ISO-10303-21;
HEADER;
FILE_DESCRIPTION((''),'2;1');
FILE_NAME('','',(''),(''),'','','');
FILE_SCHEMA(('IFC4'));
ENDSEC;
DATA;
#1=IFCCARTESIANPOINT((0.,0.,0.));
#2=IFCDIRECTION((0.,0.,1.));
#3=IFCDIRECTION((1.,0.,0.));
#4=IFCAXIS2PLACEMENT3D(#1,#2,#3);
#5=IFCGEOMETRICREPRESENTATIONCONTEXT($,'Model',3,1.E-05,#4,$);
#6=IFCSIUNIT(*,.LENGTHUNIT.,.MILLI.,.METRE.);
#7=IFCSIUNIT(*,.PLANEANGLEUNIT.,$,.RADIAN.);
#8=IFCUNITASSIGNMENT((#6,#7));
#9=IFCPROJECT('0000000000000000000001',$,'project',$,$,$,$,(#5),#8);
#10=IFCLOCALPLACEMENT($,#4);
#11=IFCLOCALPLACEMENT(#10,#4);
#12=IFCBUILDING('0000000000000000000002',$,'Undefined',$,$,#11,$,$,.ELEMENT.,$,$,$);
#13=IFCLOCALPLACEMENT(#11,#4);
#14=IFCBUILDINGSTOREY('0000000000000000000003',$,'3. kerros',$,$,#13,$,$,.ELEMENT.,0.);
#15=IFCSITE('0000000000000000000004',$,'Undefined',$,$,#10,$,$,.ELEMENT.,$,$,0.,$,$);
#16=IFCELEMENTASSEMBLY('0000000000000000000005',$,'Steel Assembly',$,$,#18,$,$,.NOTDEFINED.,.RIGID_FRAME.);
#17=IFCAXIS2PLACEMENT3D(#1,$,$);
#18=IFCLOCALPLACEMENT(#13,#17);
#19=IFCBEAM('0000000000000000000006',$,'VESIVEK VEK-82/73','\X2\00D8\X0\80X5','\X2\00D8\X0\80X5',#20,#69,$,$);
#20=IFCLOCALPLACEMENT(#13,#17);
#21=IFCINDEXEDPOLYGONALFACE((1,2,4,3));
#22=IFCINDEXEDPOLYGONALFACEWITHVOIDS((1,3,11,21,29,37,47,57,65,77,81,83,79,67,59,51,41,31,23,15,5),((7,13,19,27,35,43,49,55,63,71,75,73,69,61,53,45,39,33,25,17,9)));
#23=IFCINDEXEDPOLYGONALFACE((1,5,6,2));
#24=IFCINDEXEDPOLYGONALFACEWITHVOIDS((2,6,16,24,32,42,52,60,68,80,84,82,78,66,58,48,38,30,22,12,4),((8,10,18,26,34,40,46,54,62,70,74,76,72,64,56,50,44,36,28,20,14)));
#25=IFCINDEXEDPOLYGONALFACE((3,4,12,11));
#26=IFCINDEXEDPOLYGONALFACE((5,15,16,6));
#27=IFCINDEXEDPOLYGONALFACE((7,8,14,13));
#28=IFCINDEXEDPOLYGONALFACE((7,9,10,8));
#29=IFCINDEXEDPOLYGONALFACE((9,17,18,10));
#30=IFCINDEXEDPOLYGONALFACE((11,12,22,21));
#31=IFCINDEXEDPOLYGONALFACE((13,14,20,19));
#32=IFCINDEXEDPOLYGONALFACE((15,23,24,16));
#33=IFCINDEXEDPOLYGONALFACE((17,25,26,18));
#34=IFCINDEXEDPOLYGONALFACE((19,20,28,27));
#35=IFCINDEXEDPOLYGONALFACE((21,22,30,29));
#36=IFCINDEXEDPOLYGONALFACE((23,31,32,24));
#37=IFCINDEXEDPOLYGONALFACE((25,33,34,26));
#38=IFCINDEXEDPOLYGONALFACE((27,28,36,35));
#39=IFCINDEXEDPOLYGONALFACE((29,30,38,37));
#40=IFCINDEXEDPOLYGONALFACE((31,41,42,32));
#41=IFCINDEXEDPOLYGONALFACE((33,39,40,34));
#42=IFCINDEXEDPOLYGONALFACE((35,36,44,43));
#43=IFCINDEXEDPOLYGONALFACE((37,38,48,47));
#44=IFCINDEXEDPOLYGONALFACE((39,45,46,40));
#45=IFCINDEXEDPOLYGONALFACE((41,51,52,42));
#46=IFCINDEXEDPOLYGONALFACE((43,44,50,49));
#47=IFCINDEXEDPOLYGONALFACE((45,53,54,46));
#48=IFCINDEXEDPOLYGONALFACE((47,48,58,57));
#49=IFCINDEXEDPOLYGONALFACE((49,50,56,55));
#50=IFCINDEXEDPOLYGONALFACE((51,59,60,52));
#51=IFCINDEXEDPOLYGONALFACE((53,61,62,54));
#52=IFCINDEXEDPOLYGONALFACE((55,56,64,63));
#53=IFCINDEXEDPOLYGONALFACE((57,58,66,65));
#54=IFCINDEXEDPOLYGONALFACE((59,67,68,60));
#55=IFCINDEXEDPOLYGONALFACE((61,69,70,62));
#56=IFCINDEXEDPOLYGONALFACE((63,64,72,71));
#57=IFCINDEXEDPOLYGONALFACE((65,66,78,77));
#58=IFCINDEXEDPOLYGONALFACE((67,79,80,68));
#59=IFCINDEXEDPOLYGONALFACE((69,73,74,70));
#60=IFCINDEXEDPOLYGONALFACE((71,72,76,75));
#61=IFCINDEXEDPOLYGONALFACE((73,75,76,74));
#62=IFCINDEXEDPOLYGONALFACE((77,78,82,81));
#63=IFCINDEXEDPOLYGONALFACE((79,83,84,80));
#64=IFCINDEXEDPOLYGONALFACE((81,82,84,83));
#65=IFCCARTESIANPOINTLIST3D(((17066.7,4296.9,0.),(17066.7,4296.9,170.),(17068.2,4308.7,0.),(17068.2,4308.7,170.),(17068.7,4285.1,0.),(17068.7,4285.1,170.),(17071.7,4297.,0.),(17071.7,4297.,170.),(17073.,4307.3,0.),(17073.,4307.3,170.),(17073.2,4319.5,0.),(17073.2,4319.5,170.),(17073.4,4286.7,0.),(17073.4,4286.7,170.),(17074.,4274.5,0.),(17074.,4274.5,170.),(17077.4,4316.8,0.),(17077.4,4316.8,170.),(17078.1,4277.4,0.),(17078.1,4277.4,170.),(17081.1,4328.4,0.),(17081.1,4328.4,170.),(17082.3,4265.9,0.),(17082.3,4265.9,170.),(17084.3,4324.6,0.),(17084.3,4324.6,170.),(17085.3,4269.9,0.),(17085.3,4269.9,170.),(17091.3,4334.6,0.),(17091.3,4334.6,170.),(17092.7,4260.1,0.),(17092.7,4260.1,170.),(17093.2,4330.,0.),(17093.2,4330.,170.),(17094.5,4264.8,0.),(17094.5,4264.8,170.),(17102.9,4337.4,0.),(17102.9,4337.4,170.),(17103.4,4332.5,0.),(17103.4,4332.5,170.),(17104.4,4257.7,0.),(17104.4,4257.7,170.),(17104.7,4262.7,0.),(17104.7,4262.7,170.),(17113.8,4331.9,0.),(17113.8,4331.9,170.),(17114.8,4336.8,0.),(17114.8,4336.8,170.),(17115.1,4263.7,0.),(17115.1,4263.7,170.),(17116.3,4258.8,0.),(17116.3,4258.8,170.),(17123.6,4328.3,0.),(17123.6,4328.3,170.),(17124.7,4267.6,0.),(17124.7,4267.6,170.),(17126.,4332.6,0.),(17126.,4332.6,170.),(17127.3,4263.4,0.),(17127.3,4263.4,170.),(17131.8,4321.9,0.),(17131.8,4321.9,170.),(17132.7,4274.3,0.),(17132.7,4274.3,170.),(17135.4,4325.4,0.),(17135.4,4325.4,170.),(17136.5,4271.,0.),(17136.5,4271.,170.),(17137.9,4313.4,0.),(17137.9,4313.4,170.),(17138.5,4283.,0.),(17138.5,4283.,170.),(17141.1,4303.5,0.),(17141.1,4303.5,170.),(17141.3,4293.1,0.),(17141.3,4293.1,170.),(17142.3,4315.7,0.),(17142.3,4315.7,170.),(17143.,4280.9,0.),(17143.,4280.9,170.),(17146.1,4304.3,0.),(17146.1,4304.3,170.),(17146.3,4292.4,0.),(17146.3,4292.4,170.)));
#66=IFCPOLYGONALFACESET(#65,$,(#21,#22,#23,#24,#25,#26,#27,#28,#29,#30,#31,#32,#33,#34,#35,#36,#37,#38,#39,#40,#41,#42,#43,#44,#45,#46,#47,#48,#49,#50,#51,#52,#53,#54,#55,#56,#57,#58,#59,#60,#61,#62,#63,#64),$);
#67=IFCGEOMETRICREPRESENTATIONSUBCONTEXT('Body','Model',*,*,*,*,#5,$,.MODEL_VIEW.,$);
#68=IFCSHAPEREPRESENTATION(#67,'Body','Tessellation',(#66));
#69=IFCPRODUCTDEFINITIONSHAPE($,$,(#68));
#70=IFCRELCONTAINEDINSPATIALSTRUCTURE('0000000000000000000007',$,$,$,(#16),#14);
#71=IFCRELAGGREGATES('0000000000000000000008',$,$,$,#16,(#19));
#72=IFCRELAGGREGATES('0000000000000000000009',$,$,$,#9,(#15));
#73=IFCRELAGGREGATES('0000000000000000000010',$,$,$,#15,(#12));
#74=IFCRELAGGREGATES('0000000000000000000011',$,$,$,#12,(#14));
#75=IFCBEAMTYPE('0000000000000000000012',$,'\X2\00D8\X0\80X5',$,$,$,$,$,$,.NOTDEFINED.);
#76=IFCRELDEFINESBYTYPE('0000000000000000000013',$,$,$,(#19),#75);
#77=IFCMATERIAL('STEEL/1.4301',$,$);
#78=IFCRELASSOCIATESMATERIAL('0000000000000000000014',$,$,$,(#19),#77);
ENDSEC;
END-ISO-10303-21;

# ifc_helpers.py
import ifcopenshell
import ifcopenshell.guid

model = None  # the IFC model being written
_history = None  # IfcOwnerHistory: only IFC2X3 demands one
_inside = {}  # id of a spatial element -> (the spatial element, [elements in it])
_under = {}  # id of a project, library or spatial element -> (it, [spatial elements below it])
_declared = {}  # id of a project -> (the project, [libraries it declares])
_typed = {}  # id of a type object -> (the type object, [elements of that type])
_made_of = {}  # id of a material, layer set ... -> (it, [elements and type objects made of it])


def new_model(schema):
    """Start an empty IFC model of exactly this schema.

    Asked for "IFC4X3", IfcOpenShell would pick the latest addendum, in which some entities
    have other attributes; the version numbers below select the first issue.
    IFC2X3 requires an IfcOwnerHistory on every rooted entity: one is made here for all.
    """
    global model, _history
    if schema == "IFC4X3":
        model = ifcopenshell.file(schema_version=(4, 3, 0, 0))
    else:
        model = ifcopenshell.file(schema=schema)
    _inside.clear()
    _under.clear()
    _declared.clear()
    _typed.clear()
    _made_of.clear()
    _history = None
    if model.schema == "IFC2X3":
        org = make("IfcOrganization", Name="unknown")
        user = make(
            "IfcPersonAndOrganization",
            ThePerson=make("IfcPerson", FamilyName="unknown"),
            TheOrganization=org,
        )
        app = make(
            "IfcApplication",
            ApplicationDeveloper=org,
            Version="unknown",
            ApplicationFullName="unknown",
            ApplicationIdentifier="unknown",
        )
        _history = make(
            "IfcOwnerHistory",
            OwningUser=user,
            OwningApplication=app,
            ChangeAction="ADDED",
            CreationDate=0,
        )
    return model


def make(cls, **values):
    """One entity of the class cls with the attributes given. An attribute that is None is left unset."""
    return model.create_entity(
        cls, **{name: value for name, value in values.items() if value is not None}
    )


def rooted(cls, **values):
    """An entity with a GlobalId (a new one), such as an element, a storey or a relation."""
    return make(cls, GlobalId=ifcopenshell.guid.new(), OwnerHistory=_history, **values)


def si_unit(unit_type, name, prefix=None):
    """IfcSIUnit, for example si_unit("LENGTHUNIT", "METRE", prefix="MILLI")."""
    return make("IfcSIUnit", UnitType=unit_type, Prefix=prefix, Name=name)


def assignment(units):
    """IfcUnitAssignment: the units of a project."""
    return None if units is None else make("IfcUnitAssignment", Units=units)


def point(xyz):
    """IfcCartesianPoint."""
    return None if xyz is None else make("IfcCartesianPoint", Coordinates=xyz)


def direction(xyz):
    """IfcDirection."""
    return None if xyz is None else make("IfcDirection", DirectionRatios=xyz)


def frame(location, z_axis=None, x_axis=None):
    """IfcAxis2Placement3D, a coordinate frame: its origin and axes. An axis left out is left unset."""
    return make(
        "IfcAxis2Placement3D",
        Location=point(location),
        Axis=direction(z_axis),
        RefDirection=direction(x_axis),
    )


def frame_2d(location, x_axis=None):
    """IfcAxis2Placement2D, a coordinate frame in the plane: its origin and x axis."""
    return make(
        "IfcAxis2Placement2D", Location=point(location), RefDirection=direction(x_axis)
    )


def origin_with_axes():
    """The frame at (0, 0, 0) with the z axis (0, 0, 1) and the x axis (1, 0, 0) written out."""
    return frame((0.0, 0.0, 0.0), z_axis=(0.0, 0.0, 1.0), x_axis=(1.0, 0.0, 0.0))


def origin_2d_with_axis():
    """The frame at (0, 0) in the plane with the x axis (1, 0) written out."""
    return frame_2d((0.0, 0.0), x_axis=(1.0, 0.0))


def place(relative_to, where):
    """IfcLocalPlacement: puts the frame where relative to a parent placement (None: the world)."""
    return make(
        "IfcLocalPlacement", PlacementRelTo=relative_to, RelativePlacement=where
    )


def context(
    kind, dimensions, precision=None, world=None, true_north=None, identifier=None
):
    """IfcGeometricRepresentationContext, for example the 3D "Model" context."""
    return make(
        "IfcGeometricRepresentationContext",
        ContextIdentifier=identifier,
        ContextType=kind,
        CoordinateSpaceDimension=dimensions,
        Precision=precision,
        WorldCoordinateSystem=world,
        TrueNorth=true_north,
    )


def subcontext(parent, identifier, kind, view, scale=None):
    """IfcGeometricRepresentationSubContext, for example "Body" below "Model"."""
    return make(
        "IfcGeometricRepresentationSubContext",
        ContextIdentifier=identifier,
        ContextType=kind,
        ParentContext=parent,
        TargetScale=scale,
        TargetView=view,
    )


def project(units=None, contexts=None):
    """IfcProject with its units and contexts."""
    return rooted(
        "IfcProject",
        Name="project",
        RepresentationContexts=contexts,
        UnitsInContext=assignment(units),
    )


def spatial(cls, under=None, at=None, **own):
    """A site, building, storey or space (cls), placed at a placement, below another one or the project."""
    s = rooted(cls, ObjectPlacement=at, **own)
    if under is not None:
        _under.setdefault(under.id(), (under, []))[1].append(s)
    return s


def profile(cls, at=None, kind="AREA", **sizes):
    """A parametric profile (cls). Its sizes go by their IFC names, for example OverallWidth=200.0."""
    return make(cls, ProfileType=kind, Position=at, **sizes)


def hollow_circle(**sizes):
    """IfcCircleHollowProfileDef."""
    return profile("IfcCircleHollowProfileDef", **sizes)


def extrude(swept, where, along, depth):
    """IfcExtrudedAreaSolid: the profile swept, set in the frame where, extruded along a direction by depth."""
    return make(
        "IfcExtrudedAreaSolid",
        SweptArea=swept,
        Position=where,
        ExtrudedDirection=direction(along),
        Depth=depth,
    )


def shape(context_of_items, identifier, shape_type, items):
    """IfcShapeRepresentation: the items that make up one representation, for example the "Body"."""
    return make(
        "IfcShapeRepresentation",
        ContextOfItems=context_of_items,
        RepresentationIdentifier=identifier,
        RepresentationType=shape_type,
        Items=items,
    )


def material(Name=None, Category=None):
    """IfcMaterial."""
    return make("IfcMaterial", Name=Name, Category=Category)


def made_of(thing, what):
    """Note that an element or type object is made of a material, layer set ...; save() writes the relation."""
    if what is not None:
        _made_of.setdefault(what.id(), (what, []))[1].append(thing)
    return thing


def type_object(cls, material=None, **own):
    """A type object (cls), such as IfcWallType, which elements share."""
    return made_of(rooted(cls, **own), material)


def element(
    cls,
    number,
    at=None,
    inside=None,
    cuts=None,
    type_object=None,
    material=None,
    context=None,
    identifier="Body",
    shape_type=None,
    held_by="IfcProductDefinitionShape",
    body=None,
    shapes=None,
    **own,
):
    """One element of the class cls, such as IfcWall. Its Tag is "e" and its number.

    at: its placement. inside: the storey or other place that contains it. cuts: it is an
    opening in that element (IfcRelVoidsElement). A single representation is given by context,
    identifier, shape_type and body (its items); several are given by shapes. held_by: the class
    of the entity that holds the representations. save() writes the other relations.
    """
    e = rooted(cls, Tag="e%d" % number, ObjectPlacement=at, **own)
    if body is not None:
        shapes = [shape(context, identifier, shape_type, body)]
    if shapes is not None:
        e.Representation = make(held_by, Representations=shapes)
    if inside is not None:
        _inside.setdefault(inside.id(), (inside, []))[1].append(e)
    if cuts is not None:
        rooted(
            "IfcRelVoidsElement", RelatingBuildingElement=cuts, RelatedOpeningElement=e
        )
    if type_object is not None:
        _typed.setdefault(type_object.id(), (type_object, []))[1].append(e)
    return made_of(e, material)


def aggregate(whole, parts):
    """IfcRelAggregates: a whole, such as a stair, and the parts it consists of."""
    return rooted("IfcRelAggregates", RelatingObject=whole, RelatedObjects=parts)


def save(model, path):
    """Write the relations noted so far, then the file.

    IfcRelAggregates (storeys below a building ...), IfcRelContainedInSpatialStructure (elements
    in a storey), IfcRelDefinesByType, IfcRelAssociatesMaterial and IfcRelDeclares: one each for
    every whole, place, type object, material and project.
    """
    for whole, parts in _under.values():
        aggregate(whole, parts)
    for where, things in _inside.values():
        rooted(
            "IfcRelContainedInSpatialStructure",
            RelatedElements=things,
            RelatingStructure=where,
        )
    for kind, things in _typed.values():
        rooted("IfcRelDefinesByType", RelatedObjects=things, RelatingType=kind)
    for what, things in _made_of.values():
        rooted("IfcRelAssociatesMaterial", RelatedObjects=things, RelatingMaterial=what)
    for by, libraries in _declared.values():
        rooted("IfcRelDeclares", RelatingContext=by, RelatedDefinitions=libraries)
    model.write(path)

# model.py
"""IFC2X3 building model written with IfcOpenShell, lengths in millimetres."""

from ifc_helpers import new_model, si_unit, frame, origin_with_axes, origin_2d_with_axis, place, context, subcontext, project, spatial, hollow_circle, extrude, material, type_object, element, aggregate, save


model = new_model("IFC2X3")

# Units and contexts
model_context = context("Model", 3, precision=1e-05, world=origin_with_axes())
body_context = subcontext(model_context, "Body", "Model", "MODEL_VIEW")
ifc_project = project(units=[si_unit("LENGTHUNIT", "METRE", prefix="MILLI"), si_unit("PLANEANGLEUNIT", "RADIAN")], contexts=[model_context])

# Site, building, storey
site_placement = place(None, origin_with_axes())
site = spatial("IfcSite", under=ifc_project, at=site_placement, Name="Undefined", CompositionType="ELEMENT", RefElevation=0.0)
building_placement = place(site_placement, origin_with_axes())
building = spatial("IfcBuilding", under=site, at=building_placement, Name="Undefined", CompositionType="ELEMENT")
storey_placement = place(building_placement, origin_with_axes())
storey = spatial("IfcBuildingStorey", under=building, at=storey_placement, Name="3. kerros", CompositionType="ELEMENT", Elevation=0.0)

# Element assembly, beam
assembly_1_placement = place(storey_placement, origin_with_axes())
assembly_1 = element("IfcElementAssembly", 1, at=assembly_1_placement, inside=storey, Name="Steel Assembly", AssemblyPlace="NOTDEFINED", PredefinedType="RIGID_FRAME")
ifc_material_1 = material(Name="STEEL/1.4301")
beam_type = type_object("IfcBeamType", Name="Ø80X5", PredefinedType="NOTDEFINED")
beam_placement = place(assembly_1_placement, frame((17106.6, 4297.6, 170.0), z_axis=(-0.45079, 0.89263, 0.0), x_axis=(0.0, 0.0, -1.0)))
beam = element("IfcBeam", 2, at=beam_placement, type_object=beam_type, material=ifc_material_1, Name="VESIVEK VEK-82/73", Description="Ø80X5", ObjectType="Ø80X5", context=body_context, shape_type="SweptSolid", body=[
    extrude(hollow_circle(Radius=40.0, WallThickness=5.0, at=origin_2d_with_axis()), frame((170.0, 0.0, 0.0), z_axis=(-1.0, 0.0, 0.0), x_axis=(0.0, -1.0, 0.0)), (0.0, 0.0, 1.0), 170.0),
])
aggregate(assembly_1, [beam])

save(model, "model.ifc")
